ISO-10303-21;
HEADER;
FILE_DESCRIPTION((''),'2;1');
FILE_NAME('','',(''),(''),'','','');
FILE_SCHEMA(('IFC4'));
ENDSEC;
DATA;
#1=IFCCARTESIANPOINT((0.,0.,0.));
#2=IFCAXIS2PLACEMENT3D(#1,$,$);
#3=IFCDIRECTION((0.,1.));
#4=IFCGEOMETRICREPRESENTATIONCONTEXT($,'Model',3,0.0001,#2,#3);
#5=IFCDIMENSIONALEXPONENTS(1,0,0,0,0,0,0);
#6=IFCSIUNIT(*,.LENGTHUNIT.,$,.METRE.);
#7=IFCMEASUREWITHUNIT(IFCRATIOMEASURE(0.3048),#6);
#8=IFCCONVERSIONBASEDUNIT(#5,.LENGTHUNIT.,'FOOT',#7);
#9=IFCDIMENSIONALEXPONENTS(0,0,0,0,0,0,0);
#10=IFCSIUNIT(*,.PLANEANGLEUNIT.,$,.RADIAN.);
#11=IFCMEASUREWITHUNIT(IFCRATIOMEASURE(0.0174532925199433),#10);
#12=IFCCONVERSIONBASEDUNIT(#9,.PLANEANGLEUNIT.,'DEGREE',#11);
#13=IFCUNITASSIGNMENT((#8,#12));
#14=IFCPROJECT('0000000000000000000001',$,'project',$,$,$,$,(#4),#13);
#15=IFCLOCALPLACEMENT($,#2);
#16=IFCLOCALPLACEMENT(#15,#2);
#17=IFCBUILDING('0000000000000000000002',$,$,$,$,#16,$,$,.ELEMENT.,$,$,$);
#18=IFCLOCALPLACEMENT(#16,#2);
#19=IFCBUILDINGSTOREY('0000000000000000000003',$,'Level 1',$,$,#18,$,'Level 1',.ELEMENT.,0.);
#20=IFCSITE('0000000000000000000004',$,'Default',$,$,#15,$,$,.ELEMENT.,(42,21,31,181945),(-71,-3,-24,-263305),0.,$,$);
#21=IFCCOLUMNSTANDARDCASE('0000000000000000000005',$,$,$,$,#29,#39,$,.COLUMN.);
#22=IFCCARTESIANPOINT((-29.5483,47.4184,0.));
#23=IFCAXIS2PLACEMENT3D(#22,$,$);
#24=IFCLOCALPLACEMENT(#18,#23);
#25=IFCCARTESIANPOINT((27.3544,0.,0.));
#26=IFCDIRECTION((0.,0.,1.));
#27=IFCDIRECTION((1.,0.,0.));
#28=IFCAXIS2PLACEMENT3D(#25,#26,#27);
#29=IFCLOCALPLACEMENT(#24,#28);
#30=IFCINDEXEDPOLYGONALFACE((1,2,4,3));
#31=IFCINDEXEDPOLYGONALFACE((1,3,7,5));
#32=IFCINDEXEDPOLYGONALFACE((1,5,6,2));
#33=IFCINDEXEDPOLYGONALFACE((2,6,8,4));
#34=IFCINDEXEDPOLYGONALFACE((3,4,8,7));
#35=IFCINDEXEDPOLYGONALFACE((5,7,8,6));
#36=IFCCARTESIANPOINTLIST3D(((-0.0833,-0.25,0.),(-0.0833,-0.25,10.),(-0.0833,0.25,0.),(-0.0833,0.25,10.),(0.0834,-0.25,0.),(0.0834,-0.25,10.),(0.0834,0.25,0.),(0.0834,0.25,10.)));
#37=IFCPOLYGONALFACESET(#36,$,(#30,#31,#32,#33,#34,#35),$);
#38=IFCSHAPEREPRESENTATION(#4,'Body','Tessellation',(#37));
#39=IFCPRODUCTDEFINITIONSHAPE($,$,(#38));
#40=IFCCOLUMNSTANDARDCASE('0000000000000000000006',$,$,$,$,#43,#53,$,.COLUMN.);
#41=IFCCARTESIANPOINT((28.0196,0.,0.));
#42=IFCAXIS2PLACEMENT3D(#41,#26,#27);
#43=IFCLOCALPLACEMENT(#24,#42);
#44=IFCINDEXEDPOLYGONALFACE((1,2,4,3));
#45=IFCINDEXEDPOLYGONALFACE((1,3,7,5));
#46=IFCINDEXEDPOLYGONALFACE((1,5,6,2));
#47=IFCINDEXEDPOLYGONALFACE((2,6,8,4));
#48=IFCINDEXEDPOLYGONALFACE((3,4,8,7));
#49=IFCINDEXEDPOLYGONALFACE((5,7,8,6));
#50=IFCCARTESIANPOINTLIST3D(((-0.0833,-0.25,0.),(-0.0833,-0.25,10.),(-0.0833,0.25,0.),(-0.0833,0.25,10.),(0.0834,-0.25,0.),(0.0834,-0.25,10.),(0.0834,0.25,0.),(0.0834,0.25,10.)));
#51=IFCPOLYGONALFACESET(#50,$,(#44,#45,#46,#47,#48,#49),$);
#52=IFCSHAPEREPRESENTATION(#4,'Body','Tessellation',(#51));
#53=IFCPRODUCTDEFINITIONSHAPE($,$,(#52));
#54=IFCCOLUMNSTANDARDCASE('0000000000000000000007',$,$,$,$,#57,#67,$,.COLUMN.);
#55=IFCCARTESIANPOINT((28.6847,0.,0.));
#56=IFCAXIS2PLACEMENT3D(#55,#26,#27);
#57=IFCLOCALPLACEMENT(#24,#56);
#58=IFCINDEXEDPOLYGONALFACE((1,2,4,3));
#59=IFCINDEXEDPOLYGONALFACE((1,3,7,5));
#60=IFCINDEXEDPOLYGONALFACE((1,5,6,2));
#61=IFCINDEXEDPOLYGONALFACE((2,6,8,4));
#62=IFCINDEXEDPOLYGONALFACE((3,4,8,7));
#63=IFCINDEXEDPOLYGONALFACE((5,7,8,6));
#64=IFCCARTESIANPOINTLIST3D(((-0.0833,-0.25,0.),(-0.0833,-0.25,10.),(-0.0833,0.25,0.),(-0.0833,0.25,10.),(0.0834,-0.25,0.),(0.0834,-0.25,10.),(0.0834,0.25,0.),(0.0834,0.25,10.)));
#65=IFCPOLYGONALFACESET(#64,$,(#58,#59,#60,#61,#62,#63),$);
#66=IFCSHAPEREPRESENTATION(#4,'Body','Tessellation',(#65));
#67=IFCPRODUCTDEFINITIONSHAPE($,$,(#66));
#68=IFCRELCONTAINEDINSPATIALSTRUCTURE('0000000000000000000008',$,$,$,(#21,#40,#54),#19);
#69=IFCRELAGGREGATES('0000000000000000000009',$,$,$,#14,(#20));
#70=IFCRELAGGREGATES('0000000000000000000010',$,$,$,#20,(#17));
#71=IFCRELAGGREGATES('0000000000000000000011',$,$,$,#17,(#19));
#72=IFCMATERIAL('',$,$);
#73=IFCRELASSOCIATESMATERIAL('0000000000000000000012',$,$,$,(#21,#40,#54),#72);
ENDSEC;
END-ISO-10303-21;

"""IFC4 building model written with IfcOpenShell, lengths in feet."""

from ifc_helpers import new_model, entity, si_unit, converted_unit, direction, frame, origin, place, context, project, spatial, rectangle, extrude, material, element, save


model = new_model("IFC4")

# Units and contexts
model_context = context("Model", 3, precision=0.0001, world=origin(), true_north=direction((0.0, 1.0)))
ifc_project = project(units=[converted_unit("LENGTHUNIT", "FOOT", entity("IfcRatioMeasure", 0.3048), si_unit("LENGTHUNIT", "METRE"), dimensions=[1, 0, 0, 0, 0, 0, 0]), converted_unit("PLANEANGLEUNIT", "DEGREE", entity("IfcRatioMeasure", 0.0174532925199433), si_unit("PLANEANGLEUNIT", "RADIAN"), dimensions=[0, 0, 0, 0, 0, 0, 0])], contexts=[model_context])

# Site, building, storey
site_placement = place(None, origin())
site = spatial("IfcSite", under=ifc_project, at=site_placement, Name="Default", CompositionType="ELEMENT", RefLatitude=(42, 21, 31, 181945), RefLongitude=(-71, -3, -24, -263305), RefElevation=0.0)
building_placement = place(site_placement, origin())
building = spatial("IfcBuilding", under=site, at=building_placement, CompositionType="ELEMENT")
storey_placement = place(building_placement, origin())
storey = spatial("IfcBuildingStorey", under=building, at=storey_placement, Name="Level 1", LongName="Level 1", CompositionType="ELEMENT", Elevation=0.0)

# Columns
ifc_material = material(Name="")
placement = place(storey_placement, frame((-29.5483, 47.4184, 0.0)))
for number, where, z_axis, x_axis in (
    (1, (27.3544, 0.0, 0.0), (0.0, 0.0, 1.0), (1.0, 0.0, 0.0)),
    (2, (28.0196, 0.0, 0.0), (0.0, 0.0, 1.0), (1.0, 0.0, 0.0)),
    (3, (28.6847, 0.0, 0.0), (0.0, 0.0, 1.0), (1.0, 0.0, 0.0)),
):
    element("IfcColumnStandardCase", number, at=place(placement, frame(where, z_axis=z_axis, x_axis=x_axis)), inside=storey, material=ifc_material, PredefinedType="COLUMN", context=model_context, shape_type="SweptSolid", body=[
        extrude(rectangle(XDim=0.1667, YDim=0.5), origin(), (0.0, 0.0, 1.0), 10.0),
    ])

save(model, "model.ifc")
